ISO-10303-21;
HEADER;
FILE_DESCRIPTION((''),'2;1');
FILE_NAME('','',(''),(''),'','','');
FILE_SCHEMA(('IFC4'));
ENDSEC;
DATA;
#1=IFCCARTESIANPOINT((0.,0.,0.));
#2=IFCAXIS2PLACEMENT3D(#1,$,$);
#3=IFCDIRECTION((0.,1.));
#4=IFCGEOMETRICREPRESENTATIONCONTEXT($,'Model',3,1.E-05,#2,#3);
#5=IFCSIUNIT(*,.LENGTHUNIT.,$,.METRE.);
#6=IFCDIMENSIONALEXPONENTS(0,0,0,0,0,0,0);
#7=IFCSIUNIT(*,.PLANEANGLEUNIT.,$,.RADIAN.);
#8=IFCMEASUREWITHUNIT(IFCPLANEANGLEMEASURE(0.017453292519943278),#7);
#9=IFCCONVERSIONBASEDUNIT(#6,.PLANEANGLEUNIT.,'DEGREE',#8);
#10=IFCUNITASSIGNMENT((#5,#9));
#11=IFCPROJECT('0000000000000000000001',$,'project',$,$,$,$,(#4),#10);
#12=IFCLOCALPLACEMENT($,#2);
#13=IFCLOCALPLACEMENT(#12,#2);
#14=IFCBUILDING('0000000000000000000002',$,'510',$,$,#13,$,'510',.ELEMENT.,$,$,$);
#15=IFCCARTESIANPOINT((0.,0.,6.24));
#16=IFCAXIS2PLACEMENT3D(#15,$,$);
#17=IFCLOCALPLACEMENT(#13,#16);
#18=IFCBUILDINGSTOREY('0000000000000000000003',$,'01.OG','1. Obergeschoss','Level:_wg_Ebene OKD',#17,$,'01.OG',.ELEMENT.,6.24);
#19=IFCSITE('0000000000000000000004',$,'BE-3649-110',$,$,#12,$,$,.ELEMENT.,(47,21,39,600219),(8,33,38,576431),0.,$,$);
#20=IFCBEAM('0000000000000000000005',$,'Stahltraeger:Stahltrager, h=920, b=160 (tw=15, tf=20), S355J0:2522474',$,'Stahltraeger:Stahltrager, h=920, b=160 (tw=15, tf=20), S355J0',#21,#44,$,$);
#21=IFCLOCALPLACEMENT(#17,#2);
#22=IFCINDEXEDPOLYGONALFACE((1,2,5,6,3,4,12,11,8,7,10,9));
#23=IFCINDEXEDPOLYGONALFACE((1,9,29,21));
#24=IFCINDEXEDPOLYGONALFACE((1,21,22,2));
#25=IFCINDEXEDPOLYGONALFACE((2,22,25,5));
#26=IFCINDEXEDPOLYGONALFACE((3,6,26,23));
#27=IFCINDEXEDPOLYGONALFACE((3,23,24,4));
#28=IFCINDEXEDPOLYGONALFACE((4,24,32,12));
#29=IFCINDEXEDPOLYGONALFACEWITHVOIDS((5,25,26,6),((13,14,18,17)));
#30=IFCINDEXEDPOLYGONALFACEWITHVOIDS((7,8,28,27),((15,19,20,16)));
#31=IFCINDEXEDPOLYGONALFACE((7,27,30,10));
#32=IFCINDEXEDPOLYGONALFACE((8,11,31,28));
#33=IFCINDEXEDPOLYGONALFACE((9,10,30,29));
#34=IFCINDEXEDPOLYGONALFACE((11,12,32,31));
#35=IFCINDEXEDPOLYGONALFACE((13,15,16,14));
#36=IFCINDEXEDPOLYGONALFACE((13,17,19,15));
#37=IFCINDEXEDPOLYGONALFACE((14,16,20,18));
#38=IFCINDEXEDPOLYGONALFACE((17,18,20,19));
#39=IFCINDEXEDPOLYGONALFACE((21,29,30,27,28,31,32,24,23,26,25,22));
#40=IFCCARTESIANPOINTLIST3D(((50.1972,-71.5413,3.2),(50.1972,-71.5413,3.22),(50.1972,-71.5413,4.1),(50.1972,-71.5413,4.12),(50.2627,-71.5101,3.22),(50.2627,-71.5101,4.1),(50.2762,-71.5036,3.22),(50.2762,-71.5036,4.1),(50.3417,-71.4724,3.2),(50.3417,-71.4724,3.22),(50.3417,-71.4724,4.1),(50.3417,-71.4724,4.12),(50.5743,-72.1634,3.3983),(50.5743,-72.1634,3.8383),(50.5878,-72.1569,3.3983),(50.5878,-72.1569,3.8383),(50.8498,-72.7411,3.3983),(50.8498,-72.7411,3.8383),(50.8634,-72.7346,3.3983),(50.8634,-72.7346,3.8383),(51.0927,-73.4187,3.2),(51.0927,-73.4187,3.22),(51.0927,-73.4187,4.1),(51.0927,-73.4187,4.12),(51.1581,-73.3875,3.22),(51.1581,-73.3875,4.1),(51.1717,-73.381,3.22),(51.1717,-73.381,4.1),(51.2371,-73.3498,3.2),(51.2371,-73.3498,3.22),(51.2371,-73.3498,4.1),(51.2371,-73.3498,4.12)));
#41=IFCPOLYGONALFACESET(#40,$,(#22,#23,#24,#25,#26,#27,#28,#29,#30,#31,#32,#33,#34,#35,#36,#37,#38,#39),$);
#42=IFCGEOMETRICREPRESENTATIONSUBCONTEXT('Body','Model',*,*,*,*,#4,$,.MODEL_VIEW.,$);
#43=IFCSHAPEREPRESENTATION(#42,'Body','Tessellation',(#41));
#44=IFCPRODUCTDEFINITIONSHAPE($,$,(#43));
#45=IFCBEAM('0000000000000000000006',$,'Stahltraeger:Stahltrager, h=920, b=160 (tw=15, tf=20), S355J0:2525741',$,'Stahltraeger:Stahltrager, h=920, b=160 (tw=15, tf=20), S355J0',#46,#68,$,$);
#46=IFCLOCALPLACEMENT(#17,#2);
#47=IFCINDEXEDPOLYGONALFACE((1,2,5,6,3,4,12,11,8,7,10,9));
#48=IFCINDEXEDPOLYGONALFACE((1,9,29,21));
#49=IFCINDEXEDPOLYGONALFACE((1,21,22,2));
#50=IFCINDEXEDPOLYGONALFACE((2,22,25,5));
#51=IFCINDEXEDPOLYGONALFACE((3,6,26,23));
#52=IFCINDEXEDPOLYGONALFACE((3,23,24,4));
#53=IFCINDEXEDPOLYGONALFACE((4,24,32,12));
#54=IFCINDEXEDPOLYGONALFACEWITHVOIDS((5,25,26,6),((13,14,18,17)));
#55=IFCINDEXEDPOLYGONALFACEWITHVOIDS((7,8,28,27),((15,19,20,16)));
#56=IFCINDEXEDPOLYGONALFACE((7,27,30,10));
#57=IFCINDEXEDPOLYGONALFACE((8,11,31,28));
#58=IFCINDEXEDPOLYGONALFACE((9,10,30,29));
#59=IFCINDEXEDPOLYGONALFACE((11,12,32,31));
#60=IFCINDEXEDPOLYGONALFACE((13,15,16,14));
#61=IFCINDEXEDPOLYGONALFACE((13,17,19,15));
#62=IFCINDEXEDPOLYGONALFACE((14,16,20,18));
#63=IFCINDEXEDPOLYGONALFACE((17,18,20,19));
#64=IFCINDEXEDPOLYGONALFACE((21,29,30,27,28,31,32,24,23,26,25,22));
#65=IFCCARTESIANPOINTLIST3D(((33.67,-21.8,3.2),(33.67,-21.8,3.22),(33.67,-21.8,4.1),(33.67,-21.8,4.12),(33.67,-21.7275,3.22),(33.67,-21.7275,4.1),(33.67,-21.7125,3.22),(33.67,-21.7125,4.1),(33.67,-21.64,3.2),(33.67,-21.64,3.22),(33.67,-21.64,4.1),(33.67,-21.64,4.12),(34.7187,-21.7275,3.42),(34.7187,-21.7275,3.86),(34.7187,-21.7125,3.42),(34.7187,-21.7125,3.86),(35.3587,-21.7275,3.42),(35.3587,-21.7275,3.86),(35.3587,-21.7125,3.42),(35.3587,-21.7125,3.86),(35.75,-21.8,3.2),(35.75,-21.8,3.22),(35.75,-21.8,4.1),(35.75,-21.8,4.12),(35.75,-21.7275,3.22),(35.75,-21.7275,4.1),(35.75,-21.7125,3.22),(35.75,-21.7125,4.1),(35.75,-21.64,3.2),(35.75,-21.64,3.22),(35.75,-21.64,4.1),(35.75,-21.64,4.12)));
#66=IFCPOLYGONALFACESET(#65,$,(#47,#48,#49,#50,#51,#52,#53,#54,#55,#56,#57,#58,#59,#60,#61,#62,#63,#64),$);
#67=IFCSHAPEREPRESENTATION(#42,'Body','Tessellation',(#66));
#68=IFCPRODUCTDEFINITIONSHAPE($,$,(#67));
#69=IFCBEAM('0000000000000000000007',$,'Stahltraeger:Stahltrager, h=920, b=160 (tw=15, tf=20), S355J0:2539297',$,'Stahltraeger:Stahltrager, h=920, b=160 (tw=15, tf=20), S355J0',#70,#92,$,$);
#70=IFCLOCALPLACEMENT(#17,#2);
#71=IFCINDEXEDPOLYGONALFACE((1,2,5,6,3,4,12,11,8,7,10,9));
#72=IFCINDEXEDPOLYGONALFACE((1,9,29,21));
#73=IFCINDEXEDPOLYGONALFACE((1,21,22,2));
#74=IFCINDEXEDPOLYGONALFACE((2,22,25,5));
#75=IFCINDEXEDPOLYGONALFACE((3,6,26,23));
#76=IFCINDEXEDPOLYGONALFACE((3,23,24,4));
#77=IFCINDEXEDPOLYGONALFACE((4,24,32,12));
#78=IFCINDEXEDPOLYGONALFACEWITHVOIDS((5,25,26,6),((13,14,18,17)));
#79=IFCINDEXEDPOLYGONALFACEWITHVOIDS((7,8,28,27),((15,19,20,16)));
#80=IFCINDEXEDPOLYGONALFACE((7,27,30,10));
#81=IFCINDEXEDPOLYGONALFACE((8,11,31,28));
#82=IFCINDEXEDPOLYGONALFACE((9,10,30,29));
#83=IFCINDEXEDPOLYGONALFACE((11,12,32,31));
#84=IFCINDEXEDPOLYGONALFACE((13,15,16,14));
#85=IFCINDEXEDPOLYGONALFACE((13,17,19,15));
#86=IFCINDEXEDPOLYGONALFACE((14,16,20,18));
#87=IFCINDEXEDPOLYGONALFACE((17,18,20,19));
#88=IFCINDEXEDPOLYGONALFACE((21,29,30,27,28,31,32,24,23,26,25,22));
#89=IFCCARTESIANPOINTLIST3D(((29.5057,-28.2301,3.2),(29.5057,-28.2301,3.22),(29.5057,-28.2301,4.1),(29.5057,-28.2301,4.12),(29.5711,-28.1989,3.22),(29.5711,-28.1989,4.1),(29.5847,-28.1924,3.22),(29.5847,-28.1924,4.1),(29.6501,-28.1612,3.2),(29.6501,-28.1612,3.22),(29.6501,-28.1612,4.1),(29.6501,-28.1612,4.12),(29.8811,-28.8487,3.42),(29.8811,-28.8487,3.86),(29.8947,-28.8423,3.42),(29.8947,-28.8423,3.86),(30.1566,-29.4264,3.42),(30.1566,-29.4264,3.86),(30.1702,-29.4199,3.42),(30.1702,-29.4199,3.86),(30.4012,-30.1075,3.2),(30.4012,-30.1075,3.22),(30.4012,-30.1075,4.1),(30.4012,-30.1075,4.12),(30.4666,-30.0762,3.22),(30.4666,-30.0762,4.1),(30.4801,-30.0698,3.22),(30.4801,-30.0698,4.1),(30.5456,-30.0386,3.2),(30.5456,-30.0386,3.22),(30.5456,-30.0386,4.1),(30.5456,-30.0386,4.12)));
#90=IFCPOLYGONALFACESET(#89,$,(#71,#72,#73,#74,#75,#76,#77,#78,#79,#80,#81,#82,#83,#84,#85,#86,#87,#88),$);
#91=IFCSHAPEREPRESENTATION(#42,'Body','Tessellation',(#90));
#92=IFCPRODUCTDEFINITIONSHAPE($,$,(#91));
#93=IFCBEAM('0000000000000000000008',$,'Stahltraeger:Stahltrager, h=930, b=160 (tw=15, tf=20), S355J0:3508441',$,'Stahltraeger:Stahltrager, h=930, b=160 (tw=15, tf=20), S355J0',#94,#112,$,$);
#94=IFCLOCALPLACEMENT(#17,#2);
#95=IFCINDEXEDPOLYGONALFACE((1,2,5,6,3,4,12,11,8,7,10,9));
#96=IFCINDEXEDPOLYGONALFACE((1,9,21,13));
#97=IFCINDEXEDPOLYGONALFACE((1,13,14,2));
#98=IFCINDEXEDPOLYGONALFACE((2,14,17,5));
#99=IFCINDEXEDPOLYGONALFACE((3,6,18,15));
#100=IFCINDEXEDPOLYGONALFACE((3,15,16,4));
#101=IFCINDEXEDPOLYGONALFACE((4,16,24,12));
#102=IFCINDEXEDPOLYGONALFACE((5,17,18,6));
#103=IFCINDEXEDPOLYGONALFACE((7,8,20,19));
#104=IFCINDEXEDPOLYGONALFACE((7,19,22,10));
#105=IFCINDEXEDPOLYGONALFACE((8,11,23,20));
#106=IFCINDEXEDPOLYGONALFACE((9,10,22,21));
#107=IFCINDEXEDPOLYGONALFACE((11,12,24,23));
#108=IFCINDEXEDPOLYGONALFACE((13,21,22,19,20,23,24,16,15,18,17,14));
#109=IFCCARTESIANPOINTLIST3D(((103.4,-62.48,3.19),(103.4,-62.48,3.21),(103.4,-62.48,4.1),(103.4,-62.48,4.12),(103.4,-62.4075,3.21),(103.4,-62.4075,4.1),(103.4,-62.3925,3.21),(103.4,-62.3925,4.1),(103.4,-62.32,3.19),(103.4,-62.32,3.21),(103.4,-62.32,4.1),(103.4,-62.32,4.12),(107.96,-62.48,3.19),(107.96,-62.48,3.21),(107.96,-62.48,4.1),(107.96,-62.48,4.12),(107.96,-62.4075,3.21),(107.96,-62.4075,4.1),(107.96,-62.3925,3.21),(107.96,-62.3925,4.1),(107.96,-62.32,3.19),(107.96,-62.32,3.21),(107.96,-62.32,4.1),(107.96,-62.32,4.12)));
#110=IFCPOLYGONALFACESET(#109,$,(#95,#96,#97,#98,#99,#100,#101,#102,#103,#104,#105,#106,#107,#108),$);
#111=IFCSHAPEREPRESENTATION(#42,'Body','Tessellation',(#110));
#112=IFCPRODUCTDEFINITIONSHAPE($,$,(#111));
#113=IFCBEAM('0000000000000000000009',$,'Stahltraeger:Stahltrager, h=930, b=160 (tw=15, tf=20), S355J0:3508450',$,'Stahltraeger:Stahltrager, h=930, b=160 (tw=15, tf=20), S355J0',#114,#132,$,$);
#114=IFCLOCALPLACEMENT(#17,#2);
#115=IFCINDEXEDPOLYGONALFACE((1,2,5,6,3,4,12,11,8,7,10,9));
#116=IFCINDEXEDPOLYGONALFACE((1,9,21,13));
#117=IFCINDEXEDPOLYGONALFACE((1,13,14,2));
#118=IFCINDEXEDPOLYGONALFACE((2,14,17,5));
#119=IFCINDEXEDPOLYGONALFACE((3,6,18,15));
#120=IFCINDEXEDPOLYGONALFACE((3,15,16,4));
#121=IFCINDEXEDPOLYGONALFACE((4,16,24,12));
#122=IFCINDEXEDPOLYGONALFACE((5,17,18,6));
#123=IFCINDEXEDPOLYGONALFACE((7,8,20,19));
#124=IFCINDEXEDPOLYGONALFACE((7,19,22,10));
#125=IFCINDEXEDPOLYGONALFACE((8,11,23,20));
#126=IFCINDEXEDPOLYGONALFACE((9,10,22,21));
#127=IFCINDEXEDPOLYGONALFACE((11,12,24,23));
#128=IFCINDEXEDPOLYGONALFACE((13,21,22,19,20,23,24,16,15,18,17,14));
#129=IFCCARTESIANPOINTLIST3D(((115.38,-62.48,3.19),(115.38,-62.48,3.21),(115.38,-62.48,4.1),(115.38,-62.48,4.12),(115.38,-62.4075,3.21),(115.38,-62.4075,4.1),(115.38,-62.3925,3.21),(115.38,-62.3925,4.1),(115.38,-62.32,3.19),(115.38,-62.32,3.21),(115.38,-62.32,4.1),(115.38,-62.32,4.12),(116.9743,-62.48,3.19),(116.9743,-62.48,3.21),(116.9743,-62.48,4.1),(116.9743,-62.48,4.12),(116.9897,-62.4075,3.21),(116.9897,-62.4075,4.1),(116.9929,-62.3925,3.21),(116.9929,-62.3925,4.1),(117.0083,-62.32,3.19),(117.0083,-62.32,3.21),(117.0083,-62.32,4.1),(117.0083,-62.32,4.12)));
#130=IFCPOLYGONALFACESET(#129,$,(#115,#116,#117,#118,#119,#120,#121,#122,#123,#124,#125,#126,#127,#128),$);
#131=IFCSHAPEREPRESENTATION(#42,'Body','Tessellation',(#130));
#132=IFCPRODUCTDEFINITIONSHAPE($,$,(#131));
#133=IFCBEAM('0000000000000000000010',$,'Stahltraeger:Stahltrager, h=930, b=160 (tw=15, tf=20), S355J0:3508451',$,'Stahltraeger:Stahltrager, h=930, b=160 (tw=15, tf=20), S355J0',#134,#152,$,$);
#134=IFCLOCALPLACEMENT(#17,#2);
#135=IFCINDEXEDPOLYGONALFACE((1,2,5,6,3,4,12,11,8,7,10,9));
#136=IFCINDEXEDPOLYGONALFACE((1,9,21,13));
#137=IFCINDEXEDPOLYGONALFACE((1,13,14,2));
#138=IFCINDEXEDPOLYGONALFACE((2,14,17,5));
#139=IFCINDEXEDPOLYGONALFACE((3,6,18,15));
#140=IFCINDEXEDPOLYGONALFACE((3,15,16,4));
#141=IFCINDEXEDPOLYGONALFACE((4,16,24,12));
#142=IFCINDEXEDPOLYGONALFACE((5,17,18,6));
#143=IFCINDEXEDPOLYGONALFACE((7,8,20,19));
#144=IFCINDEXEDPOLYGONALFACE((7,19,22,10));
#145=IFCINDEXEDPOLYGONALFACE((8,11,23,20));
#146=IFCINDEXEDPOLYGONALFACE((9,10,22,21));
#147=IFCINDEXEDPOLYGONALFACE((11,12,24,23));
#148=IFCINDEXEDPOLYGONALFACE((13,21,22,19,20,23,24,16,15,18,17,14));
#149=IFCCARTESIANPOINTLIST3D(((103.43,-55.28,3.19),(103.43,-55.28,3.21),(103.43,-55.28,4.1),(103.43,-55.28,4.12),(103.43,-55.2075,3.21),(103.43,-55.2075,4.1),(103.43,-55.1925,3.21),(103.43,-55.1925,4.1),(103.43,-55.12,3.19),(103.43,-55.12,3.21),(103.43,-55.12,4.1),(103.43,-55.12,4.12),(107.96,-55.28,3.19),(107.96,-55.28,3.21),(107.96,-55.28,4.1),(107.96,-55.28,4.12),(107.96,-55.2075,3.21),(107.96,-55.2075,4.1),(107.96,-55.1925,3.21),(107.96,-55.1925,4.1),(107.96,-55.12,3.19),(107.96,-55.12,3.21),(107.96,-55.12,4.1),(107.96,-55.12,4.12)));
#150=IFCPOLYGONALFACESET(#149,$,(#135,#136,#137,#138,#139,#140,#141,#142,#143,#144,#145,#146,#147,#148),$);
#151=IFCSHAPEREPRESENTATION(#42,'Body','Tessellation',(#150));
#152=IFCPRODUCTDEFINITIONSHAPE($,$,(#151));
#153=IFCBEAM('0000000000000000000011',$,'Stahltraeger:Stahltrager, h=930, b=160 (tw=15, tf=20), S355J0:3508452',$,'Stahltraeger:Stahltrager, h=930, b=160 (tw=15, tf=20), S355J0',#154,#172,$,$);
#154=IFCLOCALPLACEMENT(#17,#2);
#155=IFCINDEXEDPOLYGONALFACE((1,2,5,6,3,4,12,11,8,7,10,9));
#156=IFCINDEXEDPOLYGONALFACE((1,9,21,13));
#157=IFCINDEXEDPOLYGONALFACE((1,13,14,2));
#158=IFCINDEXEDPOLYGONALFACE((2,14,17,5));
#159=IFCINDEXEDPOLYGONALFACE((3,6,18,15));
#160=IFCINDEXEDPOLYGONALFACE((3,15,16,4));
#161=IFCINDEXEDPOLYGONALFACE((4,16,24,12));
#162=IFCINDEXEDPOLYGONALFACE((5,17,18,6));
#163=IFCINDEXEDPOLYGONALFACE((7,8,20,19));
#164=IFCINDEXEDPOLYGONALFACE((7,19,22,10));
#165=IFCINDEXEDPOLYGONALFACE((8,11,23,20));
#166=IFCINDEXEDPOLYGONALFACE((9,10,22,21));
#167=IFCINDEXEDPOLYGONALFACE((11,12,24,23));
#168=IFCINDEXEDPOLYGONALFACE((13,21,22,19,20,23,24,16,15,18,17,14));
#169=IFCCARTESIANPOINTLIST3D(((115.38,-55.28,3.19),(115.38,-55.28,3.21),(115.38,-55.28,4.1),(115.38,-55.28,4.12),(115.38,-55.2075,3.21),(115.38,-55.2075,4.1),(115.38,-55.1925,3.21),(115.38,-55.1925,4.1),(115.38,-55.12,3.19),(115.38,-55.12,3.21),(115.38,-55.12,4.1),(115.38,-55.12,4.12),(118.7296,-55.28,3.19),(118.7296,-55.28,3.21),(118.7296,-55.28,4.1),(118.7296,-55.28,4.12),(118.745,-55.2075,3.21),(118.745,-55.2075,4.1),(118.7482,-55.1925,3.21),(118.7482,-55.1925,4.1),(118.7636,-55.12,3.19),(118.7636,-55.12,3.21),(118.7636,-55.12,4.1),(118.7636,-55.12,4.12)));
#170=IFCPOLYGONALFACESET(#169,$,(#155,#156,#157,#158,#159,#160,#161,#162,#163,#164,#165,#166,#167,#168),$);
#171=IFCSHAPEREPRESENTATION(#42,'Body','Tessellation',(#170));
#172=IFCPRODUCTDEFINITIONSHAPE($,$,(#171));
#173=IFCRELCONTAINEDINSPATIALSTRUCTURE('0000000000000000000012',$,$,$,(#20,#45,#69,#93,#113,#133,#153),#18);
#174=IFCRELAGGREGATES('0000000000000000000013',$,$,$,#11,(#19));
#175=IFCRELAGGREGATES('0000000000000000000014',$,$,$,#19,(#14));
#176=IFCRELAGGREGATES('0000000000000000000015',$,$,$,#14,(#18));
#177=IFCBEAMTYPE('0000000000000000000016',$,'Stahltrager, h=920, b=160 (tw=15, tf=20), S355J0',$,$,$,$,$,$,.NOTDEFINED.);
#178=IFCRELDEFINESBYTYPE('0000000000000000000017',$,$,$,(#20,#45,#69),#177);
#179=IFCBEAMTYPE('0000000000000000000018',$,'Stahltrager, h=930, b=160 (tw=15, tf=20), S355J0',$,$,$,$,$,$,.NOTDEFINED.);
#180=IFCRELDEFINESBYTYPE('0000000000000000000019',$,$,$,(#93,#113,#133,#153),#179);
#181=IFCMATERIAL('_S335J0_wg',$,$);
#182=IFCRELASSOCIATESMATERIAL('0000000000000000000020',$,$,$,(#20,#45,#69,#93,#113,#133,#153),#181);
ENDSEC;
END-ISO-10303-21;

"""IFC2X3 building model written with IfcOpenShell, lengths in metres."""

from ifc_helpers import new_model, entity, si_unit, converted_unit, direction, frame, frame_2d, origin, place, context, subcontext, project, spatial, polyline, rectangle, i_section, outline, extrude, boolean, clip, halfspace, material, type_object, element, save


model = new_model("IFC2X3")

# Units and contexts
model_context = context("Model", 3, precision=1e-05, world=origin(), true_north=direction((0.0, 1.0)))
body_context = subcontext(model_context, "Body", "Model", "MODEL_VIEW")
ifc_project = project(units=[si_unit("LENGTHUNIT", "METRE"), converted_unit("PLANEANGLEUNIT", "DEGREE", entity("IfcPlaneAngleMeasure", 0.017453292519943278), si_unit("PLANEANGLEUNIT", "RADIAN"), dimensions=[0, 0, 0, 0, 0, 0, 0])], contexts=[model_context])

# Site, building, storey
site_placement = place(None, origin())
site = spatial("IfcSite", under=ifc_project, at=site_placement, Name="BE-3649-110", CompositionType="ELEMENT", RefLatitude=(47, 21, 39, 600219), RefLongitude=(8, 33, 38, 576431), RefElevation=0.0)
building_placement = place(site_placement, origin())
building = spatial("IfcBuilding", under=site, at=building_placement, Name="510", LongName="510", CompositionType="ELEMENT")
storey_placement = place(building_placement, frame((0.0, 0.0, 6.24)))
storey = spatial("IfcBuildingStorey", under=building, at=storey_placement, Name="01.OG", Description="1. Obergeschoss", ObjectType="Level:_wg_Ebene OKD", LongName="01.OG", CompositionType="ELEMENT", Elevation=6.24)

# Beams
ifc_material_1 = material(Name="_S335J0_wg")
beam_type_1 = type_object("IfcBeamType", Name="Stahltrager, h=920, b=160 (tw=15, tf=20), S355J0", PredefinedType="NOTDEFINED")
beam_1_placement = place(storey_placement, frame((50.2695, -71.5068, 4.12), z_axis=(0.0, 0.0, 1.0), x_axis=(0.430511, -0.902585, 0.0)))
element("IfcBeam", 1, at=beam_1_placement, inside=storey, type_object=beam_type_1, material=ifc_material_1, Name="Stahltraeger:Stahltrager, h=920, b=160 (tw=15, tf=20), S355J0:2522474", ObjectType="Stahltraeger:Stahltrager, h=920, b=160 (tw=15, tf=20), S355J0", context=body_context, shape_type="SweptSolid", body=[
    boolean("DIFFERENCE", extrude(i_section(OverallWidth=0.16, OverallDepth=0.92, WebThickness=0.015, FlangeThickness=0.02, at=frame_2d((0.0, 0.0), x_axis=(0.0, 1.0))), frame((0.0, 0.0, -0.46), z_axis=(1.0, 0.0, 0.0), x_axis=(0.0, 0.0, -1.0)), (0.0, 0.0, 1.0), 2.08), extrude(rectangle(XDim=0.44, YDim=0.64, at=frame_2d((0.0, 0.0), x_axis=(0.0, 1.0))), frame((1.0438, 0.0075, -0.5017), z_axis=(0.0, -1.0, 0.0), x_axis=(-1.0, 0.0, 0.0)), (0.0, 0.0, 1.0), 0.015)),
])
beam_2_placement = place(storey_placement, frame((33.67, -21.72, 4.12)))
element("IfcBeam", 2, at=beam_2_placement, inside=storey, type_object=beam_type_1, material=ifc_material_1, Name="Stahltraeger:Stahltrager, h=920, b=160 (tw=15, tf=20), S355J0:2525741", ObjectType="Stahltraeger:Stahltrager, h=920, b=160 (tw=15, tf=20), S355J0", context=body_context, shape_type="SweptSolid", body=[
    boolean("DIFFERENCE", extrude(i_section(OverallWidth=0.16, OverallDepth=0.92, WebThickness=0.015, FlangeThickness=0.02, at=frame_2d((0.0, 0.0), x_axis=(0.0, 1.0))), frame((0.0, 0.0, -0.46), z_axis=(1.0, 0.0, 0.0), x_axis=(0.0, 0.0, -1.0)), (0.0, 0.0, 1.0), 2.08), extrude(rectangle(XDim=0.44, YDim=0.64, at=frame_2d((0.0, 0.0), x_axis=(0.0, 1.0))), frame((1.3687, 0.0075, -0.48), z_axis=(0.0, -1.0, 0.0), x_axis=(-1.0, 0.0, 0.0)), (0.0, 0.0, 1.0), 0.015)),
])
beam_3_placement = place(storey_placement, frame((30.4734, -30.073, 4.12), z_axis=(0.0, 0.0, 1.0), x_axis=(-0.430511, 0.902585, 0.0)))
element("IfcBeam", 3, at=beam_3_placement, inside=storey, type_object=beam_type_1, material=ifc_material_1, Name="Stahltraeger:Stahltrager, h=920, b=160 (tw=15, tf=20), S355J0:2539297", ObjectType="Stahltraeger:Stahltrager, h=920, b=160 (tw=15, tf=20), S355J0", context=body_context, shape_type="SweptSolid", body=[
    boolean("DIFFERENCE", extrude(i_section(OverallWidth=0.16, OverallDepth=0.92, WebThickness=0.015, FlangeThickness=0.02, at=frame_2d((0.0, 0.0), x_axis=(0.0, 1.0))), frame((0.0, 0.0, -0.46), z_axis=(1.0, 0.0, 0.0), x_axis=(0.0, 0.0, -1.0)), (0.0, 0.0, 1.0), 2.08), extrude(rectangle(XDim=0.44, YDim=0.64, at=frame_2d((0.0, 0.0), x_axis=(0.0, 1.0))), frame((1.04, 0.0075, -0.48), z_axis=(0.0, -1.0, 0.0), x_axis=(-1.0, 0.0, 0.0)), (0.0, 0.0, 1.0), 0.015)),
])
beam_type_2 = type_object("IfcBeamType", Name="Stahltrager, h=930, b=160 (tw=15, tf=20), S355J0", PredefinedType="NOTDEFINED")
beam_4_placement = place(storey_placement, frame((103.4, -62.48, 3.19)))
element("IfcBeam", 4, at=beam_4_placement, inside=storey, type_object=beam_type_2, material=ifc_material_1, Name="Stahltraeger:Stahltrager, h=930, b=160 (tw=15, tf=20), S355J0:3508441", ObjectType="Stahltraeger:Stahltrager, h=930, b=160 (tw=15, tf=20), S355J0", context=body_context, shape_type="SweptSolid", body=[
    extrude(outline(polyline([(-0.08, -0.445), (-0.08, -0.465), (0.08, -0.465), (0.08, -0.445), (0.0075, -0.445), (0.0075, 0.445), (0.08, 0.445), (0.08, 0.465), (-0.08, 0.465), (-0.08, 0.445), (-0.0075, 0.445), (-0.0075, -0.445), (-0.08, -0.445)])), frame((0.0, 0.08, 0.465), z_axis=(-1.0, 0.0, 0.0), x_axis=(0.0, -1.0, 0.0)), (0.0, 0.0, -1.0), 4.56),
])
beam_5_placement = place(storey_placement, frame((115.38, -62.4, 4.12)))
element("IfcBeam", 5, at=beam_5_placement, inside=storey, type_object=beam_type_2, material=ifc_material_1, Name="Stahltraeger:Stahltrager, h=930, b=160 (tw=15, tf=20), S355J0:3508450", ObjectType="Stahltraeger:Stahltrager, h=930, b=160 (tw=15, tf=20), S355J0", context=body_context, shape_type="SweptSolid", body=[
    clip(extrude(i_section(OverallWidth=0.16, OverallDepth=0.93, WebThickness=0.015, FlangeThickness=0.02, at=frame_2d((0.0, 0.0), x_axis=(0.0, 1.0))), frame((0.0, 0.0, -0.465), z_axis=(1.0, 0.0, 0.0), x_axis=(0.0, 0.0, -1.0)), (0.0, 0.0, 1.0), 1.6282), halfspace(frame((1.5374, -0.3476, 14.42), z_axis=(0.978148, -0.207912, 0.0), x_axis=(0.207912, 0.978148, 0.0)), False)),
])
beam_6_placement = place(storey_placement, frame((103.43, -55.28, 3.19)))
element("IfcBeam", 6, at=beam_6_placement, inside=storey, type_object=beam_type_2, material=ifc_material_1, Name="Stahltraeger:Stahltrager, h=930, b=160 (tw=15, tf=20), S355J0:3508451", ObjectType="Stahltraeger:Stahltrager, h=930, b=160 (tw=15, tf=20), S355J0", context=body_context, shape_type="SweptSolid", body=[
    extrude(outline(polyline([(-0.08, -0.445), (-0.08, -0.465), (0.08, -0.465), (0.08, -0.445), (0.0075, -0.445), (0.0075, 0.445), (0.08, 0.445), (0.08, 0.465), (-0.08, 0.465), (-0.08, 0.445), (-0.0075, 0.445), (-0.0075, -0.445), (-0.08, -0.445)])), frame((0.0, 0.08, 0.465), z_axis=(-1.0, 0.0, 0.0), x_axis=(0.0, -1.0, 0.0)), (0.0, 0.0, -1.0), 4.53),
])
beam_7_placement = place(storey_placement, frame((115.38, -55.2, 4.12)))
element("IfcBeam", 7, at=beam_7_placement, inside=storey, type_object=beam_type_2, material=ifc_material_1, Name="Stahltraeger:Stahltrager, h=930, b=160 (tw=15, tf=20), S355J0:3508452", ObjectType="Stahltraeger:Stahltrager, h=930, b=160 (tw=15, tf=20), S355J0", context=body_context, shape_type="SweptSolid", body=[
    clip(extrude(i_section(OverallWidth=0.16, OverallDepth=0.93, WebThickness=0.015, FlangeThickness=0.02, at=frame_2d((0.0, 0.0), x_axis=(0.0, 1.0))), frame((0.0, 0.0, -0.465), z_axis=(1.0, 0.0, 0.0), x_axis=(0.0, 0.0, -1.0)), (0.0, 0.0, 1.0), 3.3836), halfspace(frame((3.2599, -0.5018, 14.42), z_axis=(0.978148, -0.207912, 0.0), x_axis=(0.207912, 0.978148, 0.0)), False)),
])

save(model, "model.ifc")
